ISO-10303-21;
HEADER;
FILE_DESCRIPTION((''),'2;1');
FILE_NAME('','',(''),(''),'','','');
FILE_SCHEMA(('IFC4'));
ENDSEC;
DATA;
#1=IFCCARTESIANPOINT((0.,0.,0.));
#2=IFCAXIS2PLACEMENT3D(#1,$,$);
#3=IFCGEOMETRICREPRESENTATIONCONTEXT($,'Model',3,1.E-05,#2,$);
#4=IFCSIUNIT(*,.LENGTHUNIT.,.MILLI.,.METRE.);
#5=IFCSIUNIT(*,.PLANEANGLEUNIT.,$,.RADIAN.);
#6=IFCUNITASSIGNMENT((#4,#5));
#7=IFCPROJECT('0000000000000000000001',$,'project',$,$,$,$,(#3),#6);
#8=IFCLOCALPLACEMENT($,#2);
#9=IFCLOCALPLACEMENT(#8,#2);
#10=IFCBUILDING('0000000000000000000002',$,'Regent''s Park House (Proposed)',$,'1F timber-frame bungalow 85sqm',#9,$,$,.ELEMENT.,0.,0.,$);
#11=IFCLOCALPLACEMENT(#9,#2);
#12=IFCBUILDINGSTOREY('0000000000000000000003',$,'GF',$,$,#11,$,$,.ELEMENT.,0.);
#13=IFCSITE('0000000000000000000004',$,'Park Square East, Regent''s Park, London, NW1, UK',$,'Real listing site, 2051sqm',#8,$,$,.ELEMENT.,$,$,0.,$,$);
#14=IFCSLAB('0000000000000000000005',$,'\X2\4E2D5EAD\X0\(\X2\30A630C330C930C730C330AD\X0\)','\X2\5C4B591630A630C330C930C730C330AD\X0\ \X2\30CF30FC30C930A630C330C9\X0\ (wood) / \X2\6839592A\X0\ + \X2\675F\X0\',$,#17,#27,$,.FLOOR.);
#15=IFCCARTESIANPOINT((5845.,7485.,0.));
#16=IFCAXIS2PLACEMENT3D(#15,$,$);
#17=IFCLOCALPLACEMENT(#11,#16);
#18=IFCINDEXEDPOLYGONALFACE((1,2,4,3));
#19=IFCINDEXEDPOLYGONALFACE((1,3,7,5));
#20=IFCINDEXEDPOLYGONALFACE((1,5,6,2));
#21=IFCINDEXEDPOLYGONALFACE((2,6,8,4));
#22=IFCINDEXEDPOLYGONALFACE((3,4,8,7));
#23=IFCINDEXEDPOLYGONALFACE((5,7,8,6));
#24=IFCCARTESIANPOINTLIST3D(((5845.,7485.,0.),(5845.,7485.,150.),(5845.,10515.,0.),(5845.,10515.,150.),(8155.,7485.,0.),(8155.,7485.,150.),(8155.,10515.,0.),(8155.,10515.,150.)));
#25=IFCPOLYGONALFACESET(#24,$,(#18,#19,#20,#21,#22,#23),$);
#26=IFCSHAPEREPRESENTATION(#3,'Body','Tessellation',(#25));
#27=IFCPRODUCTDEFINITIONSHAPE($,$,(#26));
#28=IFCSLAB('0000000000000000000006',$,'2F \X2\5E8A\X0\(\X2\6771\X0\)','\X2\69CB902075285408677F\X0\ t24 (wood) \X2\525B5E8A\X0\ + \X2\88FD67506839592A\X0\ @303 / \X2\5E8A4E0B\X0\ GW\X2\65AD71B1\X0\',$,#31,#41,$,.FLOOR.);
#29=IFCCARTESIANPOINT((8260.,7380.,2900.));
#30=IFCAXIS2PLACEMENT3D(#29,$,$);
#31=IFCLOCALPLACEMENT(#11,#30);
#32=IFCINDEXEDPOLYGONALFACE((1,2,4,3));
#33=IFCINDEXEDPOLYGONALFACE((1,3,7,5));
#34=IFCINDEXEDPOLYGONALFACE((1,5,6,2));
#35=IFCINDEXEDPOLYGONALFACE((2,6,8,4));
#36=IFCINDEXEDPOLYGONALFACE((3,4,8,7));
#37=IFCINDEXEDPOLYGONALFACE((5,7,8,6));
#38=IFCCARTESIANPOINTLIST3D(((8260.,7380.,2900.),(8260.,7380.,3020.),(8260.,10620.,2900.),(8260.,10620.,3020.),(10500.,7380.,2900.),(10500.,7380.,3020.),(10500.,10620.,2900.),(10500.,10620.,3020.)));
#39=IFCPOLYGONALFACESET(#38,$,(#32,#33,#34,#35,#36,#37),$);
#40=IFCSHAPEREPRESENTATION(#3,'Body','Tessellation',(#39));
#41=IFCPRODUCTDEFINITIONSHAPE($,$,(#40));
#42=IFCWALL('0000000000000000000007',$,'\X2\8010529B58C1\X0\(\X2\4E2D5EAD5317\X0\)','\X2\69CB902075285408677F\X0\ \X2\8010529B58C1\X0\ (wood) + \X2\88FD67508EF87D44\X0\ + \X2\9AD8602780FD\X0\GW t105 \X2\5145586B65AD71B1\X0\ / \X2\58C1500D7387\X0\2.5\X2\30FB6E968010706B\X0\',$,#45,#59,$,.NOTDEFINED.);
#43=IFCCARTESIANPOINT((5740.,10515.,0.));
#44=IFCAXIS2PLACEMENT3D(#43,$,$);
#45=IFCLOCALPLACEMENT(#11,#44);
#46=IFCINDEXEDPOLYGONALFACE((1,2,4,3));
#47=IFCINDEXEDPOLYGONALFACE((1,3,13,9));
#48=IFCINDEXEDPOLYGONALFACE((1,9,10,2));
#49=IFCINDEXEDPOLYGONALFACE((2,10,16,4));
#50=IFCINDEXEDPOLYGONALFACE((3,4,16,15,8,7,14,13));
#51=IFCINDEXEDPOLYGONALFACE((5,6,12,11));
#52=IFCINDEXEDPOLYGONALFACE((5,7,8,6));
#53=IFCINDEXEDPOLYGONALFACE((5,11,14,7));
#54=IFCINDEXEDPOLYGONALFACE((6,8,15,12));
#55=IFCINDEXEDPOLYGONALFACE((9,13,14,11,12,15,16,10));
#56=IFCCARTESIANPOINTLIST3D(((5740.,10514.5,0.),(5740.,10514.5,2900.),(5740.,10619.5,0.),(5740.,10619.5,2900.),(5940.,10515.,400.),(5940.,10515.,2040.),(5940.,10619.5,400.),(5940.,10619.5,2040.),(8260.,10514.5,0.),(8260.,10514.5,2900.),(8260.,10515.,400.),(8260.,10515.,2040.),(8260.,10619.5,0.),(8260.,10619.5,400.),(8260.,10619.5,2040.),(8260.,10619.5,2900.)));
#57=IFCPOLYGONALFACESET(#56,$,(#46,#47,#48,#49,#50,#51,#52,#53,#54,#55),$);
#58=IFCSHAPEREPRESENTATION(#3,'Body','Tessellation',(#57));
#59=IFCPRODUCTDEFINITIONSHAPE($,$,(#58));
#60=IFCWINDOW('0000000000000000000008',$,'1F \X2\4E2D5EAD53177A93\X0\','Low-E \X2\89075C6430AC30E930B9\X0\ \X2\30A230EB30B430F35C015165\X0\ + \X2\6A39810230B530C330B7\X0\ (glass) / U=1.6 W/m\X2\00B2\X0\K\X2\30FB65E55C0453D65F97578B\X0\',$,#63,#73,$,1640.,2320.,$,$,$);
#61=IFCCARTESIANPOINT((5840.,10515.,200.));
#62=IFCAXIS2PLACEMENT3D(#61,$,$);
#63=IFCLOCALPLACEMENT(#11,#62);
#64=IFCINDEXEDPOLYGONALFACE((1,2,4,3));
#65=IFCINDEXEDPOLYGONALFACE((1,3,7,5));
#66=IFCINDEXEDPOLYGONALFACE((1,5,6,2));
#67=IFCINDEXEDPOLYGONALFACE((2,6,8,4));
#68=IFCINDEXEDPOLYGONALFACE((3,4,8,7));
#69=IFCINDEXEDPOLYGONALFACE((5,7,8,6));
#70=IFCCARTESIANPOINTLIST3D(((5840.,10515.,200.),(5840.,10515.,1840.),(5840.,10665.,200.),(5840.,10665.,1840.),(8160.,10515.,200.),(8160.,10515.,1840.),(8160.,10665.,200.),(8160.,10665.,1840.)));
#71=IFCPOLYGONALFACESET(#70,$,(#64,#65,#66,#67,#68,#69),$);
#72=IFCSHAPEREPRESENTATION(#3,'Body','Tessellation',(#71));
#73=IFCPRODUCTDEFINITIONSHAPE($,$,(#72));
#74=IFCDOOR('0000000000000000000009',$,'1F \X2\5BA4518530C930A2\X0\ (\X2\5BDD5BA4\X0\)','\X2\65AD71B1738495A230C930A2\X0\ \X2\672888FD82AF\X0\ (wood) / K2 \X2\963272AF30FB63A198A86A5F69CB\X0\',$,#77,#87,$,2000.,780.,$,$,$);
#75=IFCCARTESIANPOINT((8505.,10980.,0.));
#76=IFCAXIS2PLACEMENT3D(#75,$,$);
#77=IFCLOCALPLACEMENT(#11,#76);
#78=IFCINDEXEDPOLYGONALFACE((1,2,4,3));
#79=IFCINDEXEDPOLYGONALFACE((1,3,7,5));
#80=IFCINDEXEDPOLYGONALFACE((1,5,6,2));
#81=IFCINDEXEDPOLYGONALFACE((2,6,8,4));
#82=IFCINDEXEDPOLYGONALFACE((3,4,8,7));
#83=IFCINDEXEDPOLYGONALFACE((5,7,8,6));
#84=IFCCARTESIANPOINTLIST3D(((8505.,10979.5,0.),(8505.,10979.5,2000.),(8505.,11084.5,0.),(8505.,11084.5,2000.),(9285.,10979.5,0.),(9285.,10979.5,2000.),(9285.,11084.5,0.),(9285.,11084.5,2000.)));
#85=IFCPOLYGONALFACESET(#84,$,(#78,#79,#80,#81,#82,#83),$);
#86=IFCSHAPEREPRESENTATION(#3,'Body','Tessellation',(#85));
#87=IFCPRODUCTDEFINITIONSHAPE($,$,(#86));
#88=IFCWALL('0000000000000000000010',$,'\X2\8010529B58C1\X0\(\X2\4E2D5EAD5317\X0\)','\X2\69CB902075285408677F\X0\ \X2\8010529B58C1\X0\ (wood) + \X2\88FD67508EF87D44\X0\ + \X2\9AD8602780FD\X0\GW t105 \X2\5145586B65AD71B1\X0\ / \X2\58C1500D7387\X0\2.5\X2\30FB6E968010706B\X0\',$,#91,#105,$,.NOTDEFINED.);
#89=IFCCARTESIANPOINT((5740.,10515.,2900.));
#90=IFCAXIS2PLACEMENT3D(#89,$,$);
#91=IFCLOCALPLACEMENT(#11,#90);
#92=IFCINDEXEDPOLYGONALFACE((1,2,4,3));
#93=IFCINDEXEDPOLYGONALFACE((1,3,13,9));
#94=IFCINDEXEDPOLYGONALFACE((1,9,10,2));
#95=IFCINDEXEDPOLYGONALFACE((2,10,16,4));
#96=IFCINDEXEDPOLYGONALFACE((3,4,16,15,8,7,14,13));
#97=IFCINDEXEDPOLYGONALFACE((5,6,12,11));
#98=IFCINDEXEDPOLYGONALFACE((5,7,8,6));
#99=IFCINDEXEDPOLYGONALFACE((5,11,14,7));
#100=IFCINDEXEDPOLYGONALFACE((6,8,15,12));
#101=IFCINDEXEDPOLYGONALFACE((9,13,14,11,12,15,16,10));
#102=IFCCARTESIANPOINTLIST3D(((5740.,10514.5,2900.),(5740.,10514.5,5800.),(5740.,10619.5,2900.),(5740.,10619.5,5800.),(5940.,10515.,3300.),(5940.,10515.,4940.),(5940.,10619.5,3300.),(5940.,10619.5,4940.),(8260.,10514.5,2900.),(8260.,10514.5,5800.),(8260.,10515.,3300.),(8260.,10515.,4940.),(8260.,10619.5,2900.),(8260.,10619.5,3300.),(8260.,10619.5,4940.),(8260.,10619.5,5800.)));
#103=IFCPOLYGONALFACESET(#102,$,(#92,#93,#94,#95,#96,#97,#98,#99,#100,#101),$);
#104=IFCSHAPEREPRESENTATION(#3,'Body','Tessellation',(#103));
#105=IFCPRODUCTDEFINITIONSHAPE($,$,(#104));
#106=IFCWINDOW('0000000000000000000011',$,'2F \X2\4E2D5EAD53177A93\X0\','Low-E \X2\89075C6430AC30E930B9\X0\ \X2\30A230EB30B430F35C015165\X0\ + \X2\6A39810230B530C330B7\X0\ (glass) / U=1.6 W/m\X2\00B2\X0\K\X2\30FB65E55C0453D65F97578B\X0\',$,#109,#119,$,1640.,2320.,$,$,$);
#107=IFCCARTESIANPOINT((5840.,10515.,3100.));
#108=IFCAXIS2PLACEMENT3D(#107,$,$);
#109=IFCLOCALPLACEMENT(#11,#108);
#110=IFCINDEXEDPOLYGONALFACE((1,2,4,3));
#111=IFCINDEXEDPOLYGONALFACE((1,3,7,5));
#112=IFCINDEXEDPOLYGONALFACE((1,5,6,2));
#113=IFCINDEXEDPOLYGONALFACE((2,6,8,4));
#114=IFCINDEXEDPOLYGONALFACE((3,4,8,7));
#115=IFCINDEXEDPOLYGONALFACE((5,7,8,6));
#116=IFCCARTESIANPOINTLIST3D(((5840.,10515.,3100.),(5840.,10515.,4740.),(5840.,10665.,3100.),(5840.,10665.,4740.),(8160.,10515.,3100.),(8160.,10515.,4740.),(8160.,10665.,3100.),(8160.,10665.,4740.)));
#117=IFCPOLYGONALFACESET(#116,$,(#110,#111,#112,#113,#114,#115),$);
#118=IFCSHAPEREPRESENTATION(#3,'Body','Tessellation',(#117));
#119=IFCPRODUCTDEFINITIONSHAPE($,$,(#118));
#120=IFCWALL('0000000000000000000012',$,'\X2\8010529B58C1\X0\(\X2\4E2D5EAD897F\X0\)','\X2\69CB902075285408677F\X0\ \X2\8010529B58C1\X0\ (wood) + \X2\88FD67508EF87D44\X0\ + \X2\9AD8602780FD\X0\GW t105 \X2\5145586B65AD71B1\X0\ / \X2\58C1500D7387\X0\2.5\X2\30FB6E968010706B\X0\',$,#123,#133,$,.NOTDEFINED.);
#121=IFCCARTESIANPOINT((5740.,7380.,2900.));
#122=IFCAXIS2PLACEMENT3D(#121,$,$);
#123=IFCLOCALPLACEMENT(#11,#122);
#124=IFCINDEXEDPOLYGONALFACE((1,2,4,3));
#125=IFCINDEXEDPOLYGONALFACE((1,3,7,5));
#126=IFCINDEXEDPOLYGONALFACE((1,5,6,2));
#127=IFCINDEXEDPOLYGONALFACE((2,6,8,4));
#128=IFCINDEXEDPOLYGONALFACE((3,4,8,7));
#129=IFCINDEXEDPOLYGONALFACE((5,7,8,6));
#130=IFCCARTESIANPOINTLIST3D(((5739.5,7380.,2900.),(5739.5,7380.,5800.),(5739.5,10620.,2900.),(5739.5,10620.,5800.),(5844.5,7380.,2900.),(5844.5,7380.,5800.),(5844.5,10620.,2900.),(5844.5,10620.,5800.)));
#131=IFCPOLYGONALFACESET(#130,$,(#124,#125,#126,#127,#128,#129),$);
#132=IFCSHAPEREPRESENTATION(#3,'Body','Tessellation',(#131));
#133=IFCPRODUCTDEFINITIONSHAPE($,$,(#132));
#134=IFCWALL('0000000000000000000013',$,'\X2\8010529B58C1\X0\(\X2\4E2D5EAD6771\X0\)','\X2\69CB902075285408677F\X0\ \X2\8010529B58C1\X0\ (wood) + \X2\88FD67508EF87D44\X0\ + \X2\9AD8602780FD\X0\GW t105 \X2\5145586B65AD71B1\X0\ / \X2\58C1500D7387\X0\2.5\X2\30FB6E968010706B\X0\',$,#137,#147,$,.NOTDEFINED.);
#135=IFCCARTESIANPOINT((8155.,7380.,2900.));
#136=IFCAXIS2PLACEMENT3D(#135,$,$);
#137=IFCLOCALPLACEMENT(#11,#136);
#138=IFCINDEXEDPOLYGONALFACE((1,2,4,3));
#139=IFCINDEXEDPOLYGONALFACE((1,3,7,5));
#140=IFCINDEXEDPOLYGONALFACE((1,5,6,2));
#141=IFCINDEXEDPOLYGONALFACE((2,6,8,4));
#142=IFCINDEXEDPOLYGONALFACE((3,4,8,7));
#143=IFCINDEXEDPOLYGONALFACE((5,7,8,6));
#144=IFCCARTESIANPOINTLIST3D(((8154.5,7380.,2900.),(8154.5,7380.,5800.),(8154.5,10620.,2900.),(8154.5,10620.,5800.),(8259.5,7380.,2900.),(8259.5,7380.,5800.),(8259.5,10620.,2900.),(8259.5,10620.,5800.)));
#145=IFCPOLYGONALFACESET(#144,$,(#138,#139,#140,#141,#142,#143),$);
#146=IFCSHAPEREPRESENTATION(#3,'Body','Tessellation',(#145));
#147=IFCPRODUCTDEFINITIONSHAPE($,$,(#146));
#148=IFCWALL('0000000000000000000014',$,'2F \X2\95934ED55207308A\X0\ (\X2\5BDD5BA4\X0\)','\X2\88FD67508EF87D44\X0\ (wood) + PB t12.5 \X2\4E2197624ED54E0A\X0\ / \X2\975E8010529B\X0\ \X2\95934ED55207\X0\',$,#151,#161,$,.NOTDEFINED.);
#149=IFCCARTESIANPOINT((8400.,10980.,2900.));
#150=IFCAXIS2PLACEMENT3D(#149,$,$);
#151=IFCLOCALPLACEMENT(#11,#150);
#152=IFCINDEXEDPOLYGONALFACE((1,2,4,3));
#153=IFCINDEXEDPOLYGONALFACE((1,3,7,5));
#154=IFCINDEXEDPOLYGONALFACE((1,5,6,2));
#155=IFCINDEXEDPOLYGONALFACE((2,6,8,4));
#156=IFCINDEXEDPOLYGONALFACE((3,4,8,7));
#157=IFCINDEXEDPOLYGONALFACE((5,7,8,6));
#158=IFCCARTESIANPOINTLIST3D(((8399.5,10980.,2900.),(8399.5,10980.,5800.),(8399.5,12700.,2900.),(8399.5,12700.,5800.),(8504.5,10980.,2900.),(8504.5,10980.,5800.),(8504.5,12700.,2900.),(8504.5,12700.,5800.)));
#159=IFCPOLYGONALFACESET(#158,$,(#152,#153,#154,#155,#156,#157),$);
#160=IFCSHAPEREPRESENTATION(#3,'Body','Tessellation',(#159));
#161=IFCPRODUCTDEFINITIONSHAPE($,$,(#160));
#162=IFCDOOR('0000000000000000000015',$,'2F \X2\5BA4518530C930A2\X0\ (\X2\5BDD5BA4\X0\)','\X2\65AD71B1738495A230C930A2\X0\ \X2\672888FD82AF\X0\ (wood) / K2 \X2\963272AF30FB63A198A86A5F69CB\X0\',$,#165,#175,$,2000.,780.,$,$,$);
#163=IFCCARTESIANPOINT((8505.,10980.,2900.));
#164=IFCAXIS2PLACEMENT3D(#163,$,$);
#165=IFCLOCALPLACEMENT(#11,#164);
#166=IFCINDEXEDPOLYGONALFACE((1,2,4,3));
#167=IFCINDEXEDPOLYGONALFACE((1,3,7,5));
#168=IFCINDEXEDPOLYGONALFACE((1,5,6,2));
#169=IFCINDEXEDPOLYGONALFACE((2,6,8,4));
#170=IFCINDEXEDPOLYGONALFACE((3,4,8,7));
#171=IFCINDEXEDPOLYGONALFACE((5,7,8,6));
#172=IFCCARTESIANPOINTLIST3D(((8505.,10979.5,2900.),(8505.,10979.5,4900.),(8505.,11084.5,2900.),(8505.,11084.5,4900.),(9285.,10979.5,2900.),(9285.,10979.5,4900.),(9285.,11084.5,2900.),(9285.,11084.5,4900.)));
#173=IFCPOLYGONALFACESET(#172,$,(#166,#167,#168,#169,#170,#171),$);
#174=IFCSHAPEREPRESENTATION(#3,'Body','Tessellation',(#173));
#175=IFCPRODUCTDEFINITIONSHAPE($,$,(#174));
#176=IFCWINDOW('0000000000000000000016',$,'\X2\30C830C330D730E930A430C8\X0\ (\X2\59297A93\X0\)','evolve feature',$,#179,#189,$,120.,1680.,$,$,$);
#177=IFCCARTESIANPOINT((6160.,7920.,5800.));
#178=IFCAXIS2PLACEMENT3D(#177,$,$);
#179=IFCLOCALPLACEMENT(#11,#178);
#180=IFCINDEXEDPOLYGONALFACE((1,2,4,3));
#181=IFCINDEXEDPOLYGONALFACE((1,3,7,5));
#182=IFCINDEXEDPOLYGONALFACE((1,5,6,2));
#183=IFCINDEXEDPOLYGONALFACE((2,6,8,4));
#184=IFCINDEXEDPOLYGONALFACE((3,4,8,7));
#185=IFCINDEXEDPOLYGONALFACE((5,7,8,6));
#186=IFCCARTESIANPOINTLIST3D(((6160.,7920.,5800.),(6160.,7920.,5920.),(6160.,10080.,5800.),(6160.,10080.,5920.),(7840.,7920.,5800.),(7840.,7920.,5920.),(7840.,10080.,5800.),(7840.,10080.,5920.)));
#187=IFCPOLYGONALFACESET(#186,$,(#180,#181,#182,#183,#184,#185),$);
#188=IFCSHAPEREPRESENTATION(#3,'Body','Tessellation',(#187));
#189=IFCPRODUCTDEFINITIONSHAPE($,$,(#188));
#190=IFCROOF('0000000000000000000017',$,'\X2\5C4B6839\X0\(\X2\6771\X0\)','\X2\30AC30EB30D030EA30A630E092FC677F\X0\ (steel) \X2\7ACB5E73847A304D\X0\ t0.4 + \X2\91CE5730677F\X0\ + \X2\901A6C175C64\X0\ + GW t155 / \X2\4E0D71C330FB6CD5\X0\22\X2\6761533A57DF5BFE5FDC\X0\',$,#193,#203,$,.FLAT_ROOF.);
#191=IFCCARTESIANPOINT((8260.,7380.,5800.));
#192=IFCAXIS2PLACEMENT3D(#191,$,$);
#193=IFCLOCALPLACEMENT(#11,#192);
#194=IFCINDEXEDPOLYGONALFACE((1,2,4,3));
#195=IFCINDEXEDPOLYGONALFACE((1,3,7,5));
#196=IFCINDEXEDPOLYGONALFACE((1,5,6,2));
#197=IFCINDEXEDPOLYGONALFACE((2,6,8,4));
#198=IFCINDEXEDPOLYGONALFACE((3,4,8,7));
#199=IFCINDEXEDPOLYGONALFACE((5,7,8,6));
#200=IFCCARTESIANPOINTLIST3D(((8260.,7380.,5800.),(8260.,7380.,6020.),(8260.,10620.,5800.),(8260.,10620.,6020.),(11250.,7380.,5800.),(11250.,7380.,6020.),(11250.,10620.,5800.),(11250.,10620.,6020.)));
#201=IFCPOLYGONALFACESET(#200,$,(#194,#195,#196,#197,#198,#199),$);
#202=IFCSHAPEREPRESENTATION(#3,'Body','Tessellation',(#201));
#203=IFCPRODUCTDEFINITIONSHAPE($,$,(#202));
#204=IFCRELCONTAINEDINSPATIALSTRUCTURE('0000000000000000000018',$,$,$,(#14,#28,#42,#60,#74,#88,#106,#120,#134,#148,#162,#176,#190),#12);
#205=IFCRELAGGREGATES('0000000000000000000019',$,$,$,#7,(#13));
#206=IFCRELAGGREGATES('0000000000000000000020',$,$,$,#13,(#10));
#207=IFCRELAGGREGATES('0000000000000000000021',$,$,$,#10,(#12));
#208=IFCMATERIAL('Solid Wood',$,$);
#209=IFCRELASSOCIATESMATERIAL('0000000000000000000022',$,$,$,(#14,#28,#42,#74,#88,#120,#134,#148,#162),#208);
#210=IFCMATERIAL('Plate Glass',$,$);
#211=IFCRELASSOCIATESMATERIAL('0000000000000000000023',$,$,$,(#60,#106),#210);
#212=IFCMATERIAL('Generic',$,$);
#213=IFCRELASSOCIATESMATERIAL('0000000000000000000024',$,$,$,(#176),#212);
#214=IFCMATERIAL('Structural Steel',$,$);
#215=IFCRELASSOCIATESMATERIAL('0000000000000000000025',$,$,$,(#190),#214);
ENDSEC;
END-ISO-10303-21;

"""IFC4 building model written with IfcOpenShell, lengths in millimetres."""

from ifc_helpers import new_model, si_unit, frame, frame_2d, origin, place, context, project, spatial, rectangle, extrude, material, element, fill, save


model = new_model("IFC4")

# Units and contexts
model_context = context("Model", 3, precision=1e-05, world=origin())
ifc_project = project(units=[si_unit("LENGTHUNIT", "METRE", prefix="MILLI"), si_unit("PLANEANGLEUNIT", "RADIAN")], contexts=[model_context])

# Site, building, storey
site_placement = place(None, origin())
site = spatial("IfcSite", under=ifc_project, at=site_placement, Name="Park Square East, Regent's Park, London, NW1, UK", ObjectType="Real listing site, 2051sqm", CompositionType="ELEMENT", RefElevation=0.0)
building_placement = place(site_placement, origin())
building = spatial("IfcBuilding", under=site, at=building_placement, Name="Regent's Park House (Proposed)", ObjectType="1F timber-frame bungalow 85sqm", CompositionType="ELEMENT", ElevationOfRefHeight=0.0, ElevationOfTerrain=0.0)
storey_placement = place(building_placement, origin())
storey = spatial("IfcBuildingStorey", under=building, at=storey_placement, Name="GF", CompositionType="ELEMENT", Elevation=0.0)

# Slabs
ifc_material_1 = material(Name="Solid Wood")
slab_1_placement = place(storey_placement, frame((5845.0, 7485.0, 0.0)))
element("IfcSlab", 1, at=slab_1_placement, inside=storey, material=ifc_material_1, Name="中庭(ウッドデッキ)", Description="屋外ウッドデッキ ハードウッド (wood) / 根太 + 束", PredefinedType="FLOOR", context=model_context, shape_type="SweptSolid", body=[
    extrude(rectangle(XDim=2310.0, YDim=3030.0, at=frame_2d((1155.0, 1515.0))), frame((5845.0, 7485.0, 0.0)), (0.0, 0.0, 1.0), 150.0),
])
slab_2_placement = place(storey_placement, frame((8260.0, 7380.0, 2900.0)))
element("IfcSlab", 2, at=slab_2_placement, inside=storey, material=ifc_material_1, Name="2F 床(東)", Description="構造用合板 t24 (wood) 剛床 + 製材根太 @303 / 床下 GW断熱", PredefinedType="FLOOR", context=model_context, shape_type="SweptSolid", body=[
    extrude(rectangle(XDim=2240.0, YDim=3240.0, at=frame_2d((1120.0, 1620.0))), frame((8260.0, 7380.0, 2900.0)), (0.0, 0.0, 1.0), 120.0),
])

# Wall, opening, window
wall_1_placement = place(storey_placement, frame((5740.0, 10515.0, 0.0)))
wall_1 = element("IfcWall", 3, at=wall_1_placement, inside=storey, material=ifc_material_1, Name="耐力壁(中庭北)", Description="構造用合板 耐力壁 (wood) + 製材軸組 + 高性能GW t105 充填断熱 / 壁倍率2.5・準耐火", PredefinedType="NOTDEFINED", context=model_context, shape_type="SweptSolid", body=[
    extrude(rectangle(XDim=2520.0, YDim=105.0, at=frame_2d((1260.0, 52.0))), frame((5740.0, 10515.0, 0.0)), (0.0, 0.0, 1.0), 2900.0),
])
opening_1_placement = place(storey_placement, frame((5840.0, 10515.0, 200.0)))
opening_1 = element("IfcOpeningElement", 4, at=opening_1_placement, cuts=wall_1, PredefinedType="NOTDEFINED", context=model_context, shape_type="SweptSolid", body=[
    extrude(rectangle(XDim=2320.0, YDim=150.0, at=frame_2d((1160.0, 75.0))), frame((5840.0, 10515.0, 200.0)), (0.0, 0.0, 1.0), 1640.0),
])
ifc_material_2 = material(Name="Plate Glass")
window_1_placement = place(storey_placement, frame((5840.0, 10515.0, 200.0)))
window_1 = element("IfcWindow", 5, at=window_1_placement, inside=storey, material=ifc_material_2, Name="1F 中庭北窓", Description="Low-E 複層ガラス アルゴン封入 + 樹脂サッシ (glass) / U=1.6 W/m²K・日射取得型", OverallHeight=1640.0, OverallWidth=2320.0, context=model_context, shape_type="SweptSolid", body=[
    extrude(rectangle(XDim=2320.0, YDim=150.0, at=frame_2d((1160.0, 75.0))), frame((5840.0, 10515.0, 200.0)), (0.0, 0.0, 1.0), 1640.0),
])
fill(opening_1, window_1)

# Door
door_1_placement = place(storey_placement, frame((8505.0, 10980.0, 0.0)))
element("IfcDoor", 6, at=door_1_placement, inside=storey, material=ifc_material_1, Name="1F 室内ドア (寝室)", Description="断熱玄関ドア 木製芯 (wood) / K2 防犯・採風機構", OverallHeight=2000.0, OverallWidth=780.0, context=model_context, shape_type="SweptSolid", body=[
    extrude(rectangle(XDim=780.0, YDim=105.0, at=frame_2d((390.0, 52.0))), frame((8505.0, 10980.0, 0.0)), (0.0, 0.0, 1.0), 2000.0),
])

# Wall, opening, window
wall_2_placement = place(storey_placement, frame((5740.0, 10515.0, 2900.0)))
wall_2 = element("IfcWall", 7, at=wall_2_placement, inside=storey, material=ifc_material_1, Name="耐力壁(中庭北)", Description="構造用合板 耐力壁 (wood) + 製材軸組 + 高性能GW t105 充填断熱 / 壁倍率2.5・準耐火", PredefinedType="NOTDEFINED", context=model_context, shape_type="SweptSolid", body=[
    extrude(rectangle(XDim=2520.0, YDim=105.0, at=frame_2d((1260.0, 52.0))), frame((5740.0, 10515.0, 2900.0)), (0.0, 0.0, 1.0), 2900.0),
])
opening_2_placement = place(storey_placement, frame((5840.0, 10515.0, 3100.0)))
opening_2 = element("IfcOpeningElement", 8, at=opening_2_placement, cuts=wall_2, PredefinedType="NOTDEFINED", context=model_context, shape_type="SweptSolid", body=[
    extrude(rectangle(XDim=2320.0, YDim=150.0, at=frame_2d((1160.0, 75.0))), frame((5840.0, 10515.0, 3100.0)), (0.0, 0.0, 1.0), 1640.0),
])
window_2_placement = place(storey_placement, frame((5840.0, 10515.0, 3100.0)))
window_2 = element("IfcWindow", 9, at=window_2_placement, inside=storey, material=ifc_material_2, Name="2F 中庭北窓", Description="Low-E 複層ガラス アルゴン封入 + 樹脂サッシ (glass) / U=1.6 W/m²K・日射取得型", OverallHeight=1640.0, OverallWidth=2320.0, context=model_context, shape_type="SweptSolid", body=[
    extrude(rectangle(XDim=2320.0, YDim=150.0, at=frame_2d((1160.0, 75.0))), frame((5840.0, 10515.0, 3100.0)), (0.0, 0.0, 1.0), 1640.0),
])
fill(opening_2, window_2)

# Walls
wall_3_placement = place(storey_placement, frame((5740.0, 7380.0, 2900.0)))
element("IfcWall", 10, at=wall_3_placement, inside=storey, material=ifc_material_1, Name="耐力壁(中庭西)", Description="構造用合板 耐力壁 (wood) + 製材軸組 + 高性能GW t105 充填断熱 / 壁倍率2.5・準耐火", PredefinedType="NOTDEFINED", context=model_context, shape_type="SweptSolid", body=[
    extrude(rectangle(XDim=105.0, YDim=3240.0, at=frame_2d((52.0, 1620.0))), frame((5740.0, 7380.0, 2900.0)), (0.0, 0.0, 1.0), 2900.0),
])
wall_4_placement = place(storey_placement, frame((8155.0, 7380.0, 2900.0)))
element("IfcWall", 11, at=wall_4_placement, inside=storey, material=ifc_material_1, Name="耐力壁(中庭東)", Description="構造用合板 耐力壁 (wood) + 製材軸組 + 高性能GW t105 充填断熱 / 壁倍率2.5・準耐火", PredefinedType="NOTDEFINED", context=model_context, shape_type="SweptSolid", body=[
    extrude(rectangle(XDim=105.0, YDim=3240.0, at=frame_2d((52.0, 1620.0))), frame((8155.0, 7380.0, 2900.0)), (0.0, 0.0, 1.0), 2900.0),
])
wall_5_placement = place(storey_placement, frame((8400.0, 10980.0, 2900.0)))
element("IfcWall", 12, at=wall_5_placement, inside=storey, material=ifc_material_1, Name="2F 間仕切り (寝室)", Description="製材軸組 (wood) + PB t12.5 両面仕上 / 非耐力 間仕切", PredefinedType="NOTDEFINED", context=model_context, shape_type="SweptSolid", body=[
    extrude(rectangle(XDim=105.0, YDim=1720.0, at=frame_2d((52.0, 860.0))), frame((8400.0, 10980.0, 2900.0)), (0.0, 0.0, 1.0), 2900.0),
])

# Door
door_2_placement = place(storey_placement, frame((8505.0, 10980.0, 2900.0)))
element("IfcDoor", 13, at=door_2_placement, inside=storey, material=ifc_material_1, Name="2F 室内ドア (寝室)", Description="断熱玄関ドア 木製芯 (wood) / K2 防犯・採風機構", OverallHeight=2000.0, OverallWidth=780.0, context=model_context, shape_type="SweptSolid", body=[
    extrude(rectangle(XDim=780.0, YDim=105.0, at=frame_2d((390.0, 52.0))), frame((8505.0, 10980.0, 2900.0)), (0.0, 0.0, 1.0), 2000.0),
])

# Window
ifc_material_3 = material(Name="Generic")
window_3_placement = place(storey_placement, frame((6160.0, 7920.0, 5800.0)))
element("IfcWindow", 14, at=window_3_placement, inside=storey, material=ifc_material_3, Name="トップライト (天窓)", Description="evolve feature", OverallHeight=120.0, OverallWidth=1680.0, context=model_context, shape_type="SweptSolid", body=[
    extrude(rectangle(XDim=1680.0, YDim=2160.0, at=frame_2d((840.0, 1080.0))), frame((6160.0, 7920.0, 5800.0)), (0.0, 0.0, 1.0), 120.0),
])

# Roof
ifc_material_4 = material(Name="Structural Steel")
roof_placement = place(storey_placement, frame((8260.0, 7380.0, 5800.0)))
element("IfcRoof", 15, at=roof_placement, inside=storey, material=ifc_material_4, Name="屋根(東)", Description="ガルバリウム鋼板 (steel) 立平葺き t0.4 + 野地板 + 通気層 + GW t155 / 不燃・法22条区域対応", PredefinedType="FLAT_ROOF", context=model_context, shape_type="SweptSolid", body=[
    extrude(rectangle(XDim=2990.0, YDim=3240.0, at=frame_2d((1495.0, 1620.0))), frame((8260.0, 7380.0, 5800.0)), (0.0, 0.0, 1.0), 220.0),
])

save(model, "model.ifc")
